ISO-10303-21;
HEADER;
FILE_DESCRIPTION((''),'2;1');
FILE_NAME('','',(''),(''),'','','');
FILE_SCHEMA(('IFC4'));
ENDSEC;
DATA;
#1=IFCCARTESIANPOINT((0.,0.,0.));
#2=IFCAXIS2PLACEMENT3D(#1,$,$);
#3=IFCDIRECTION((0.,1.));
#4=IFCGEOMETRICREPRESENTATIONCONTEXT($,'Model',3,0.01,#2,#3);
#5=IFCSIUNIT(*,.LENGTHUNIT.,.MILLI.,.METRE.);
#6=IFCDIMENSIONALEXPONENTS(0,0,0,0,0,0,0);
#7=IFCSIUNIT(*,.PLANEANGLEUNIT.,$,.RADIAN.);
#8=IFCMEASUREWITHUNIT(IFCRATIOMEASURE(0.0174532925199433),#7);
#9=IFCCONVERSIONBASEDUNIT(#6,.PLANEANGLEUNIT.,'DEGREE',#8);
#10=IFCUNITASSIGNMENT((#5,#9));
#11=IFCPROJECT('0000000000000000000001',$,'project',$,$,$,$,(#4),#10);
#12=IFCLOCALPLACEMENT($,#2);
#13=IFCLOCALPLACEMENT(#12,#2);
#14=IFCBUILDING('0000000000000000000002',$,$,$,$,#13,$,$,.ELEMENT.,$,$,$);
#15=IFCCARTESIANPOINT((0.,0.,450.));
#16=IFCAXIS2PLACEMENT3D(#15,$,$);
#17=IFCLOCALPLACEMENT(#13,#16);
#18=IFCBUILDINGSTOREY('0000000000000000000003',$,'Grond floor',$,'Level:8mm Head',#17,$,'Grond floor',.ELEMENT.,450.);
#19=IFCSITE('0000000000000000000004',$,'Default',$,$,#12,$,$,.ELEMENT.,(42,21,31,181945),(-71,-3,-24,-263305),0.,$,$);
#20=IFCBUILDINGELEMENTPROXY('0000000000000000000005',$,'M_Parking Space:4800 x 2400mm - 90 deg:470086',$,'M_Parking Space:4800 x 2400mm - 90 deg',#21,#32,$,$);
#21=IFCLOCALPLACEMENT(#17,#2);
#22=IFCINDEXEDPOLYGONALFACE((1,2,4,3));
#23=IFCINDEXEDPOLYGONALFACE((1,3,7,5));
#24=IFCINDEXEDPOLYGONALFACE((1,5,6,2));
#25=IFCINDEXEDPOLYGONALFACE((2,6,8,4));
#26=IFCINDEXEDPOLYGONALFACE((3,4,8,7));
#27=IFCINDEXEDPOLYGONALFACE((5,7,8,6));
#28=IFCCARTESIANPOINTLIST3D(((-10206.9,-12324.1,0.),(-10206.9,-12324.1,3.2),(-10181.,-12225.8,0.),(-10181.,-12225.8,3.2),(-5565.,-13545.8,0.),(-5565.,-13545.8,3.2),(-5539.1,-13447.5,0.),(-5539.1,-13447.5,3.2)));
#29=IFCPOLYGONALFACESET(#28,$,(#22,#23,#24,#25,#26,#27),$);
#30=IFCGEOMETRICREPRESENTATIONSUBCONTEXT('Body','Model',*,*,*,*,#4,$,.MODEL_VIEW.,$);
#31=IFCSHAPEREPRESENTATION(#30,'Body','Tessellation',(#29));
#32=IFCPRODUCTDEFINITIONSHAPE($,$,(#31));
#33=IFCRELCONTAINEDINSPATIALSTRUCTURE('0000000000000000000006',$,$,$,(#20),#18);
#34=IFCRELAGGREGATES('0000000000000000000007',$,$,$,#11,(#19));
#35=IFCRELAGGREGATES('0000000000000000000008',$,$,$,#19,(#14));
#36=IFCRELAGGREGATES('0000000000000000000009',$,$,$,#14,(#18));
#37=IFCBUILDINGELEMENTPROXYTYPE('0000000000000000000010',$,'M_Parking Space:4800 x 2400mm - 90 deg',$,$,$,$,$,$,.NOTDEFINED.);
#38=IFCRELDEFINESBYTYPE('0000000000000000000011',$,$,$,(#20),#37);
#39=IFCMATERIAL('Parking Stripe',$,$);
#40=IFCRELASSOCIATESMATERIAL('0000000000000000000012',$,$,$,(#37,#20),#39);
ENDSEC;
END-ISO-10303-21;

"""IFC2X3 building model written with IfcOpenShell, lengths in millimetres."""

from ifc_helpers import new_model, entity, si_unit, converted_unit, direction, frame, origin, origin_2d_with_axis, place, context, subcontext, project, spatial, rectangle, extrude, source, transform, mapped, material, type_object, type_shapes, element, save


model = new_model("IFC2X3")

# Units and contexts
model_context = context("Model", 3, precision=0.01, world=origin(), true_north=direction((0.0, 1.0)))
body_context = subcontext(model_context, "Body", "Model", "MODEL_VIEW")
ifc_project = project(units=[si_unit("LENGTHUNIT", "METRE", prefix="MILLI"), converted_unit("PLANEANGLEUNIT", "DEGREE", entity("IfcRatioMeasure", 0.0174532925199433), si_unit("PLANEANGLEUNIT", "RADIAN"), dimensions=[0, 0, 0, 0, 0, 0, 0])], contexts=[model_context])

# Site, building, storey
site_placement = place(None, origin())
site = spatial("IfcSite", under=ifc_project, at=site_placement, Name="Default", CompositionType="ELEMENT", RefLatitude=(42, 21, 31, 181945), RefLongitude=(-71, -3, -24, -263305), RefElevation=0.0)
building_placement = place(site_placement, origin())
building = spatial("IfcBuilding", under=site, at=building_placement, CompositionType="ELEMENT")
storey_placement = place(building_placement, frame((0.0, 0.0, 450.0)))
storey = spatial("IfcBuildingStorey", under=building, at=storey_placement, Name="Grond floor", ObjectType="Level:8mm Head", LongName="Grond floor", CompositionType="ELEMENT", Elevation=450.0)

# Building element proxy
ifc_material_1 = material(Name="Parking Stripe")
building_element_proxy_type_1 = type_object("IfcBuildingElementProxyType", Name="M_Parking Space:4800 x 2400mm - 90 deg", PredefinedType="NOTDEFINED", material=ifc_material_1)
shared_shape_1 = source(origin(), body_context, "Body", "SweptSolid", [
    extrude(rectangle(XDim=101.6, YDim=4800.0, at=origin_2d_with_axis()), frame((0.0, 2400.0, 0.0)), (0.0, 0.0, 1.0), 3.2),
])
type_shapes(building_element_proxy_type_1, [shared_shape_1])
proxy_1_placement = place(storey_placement, frame((-5552.0, -13496.6, 0.0), z_axis=(0.0, 0.0, 1.0), x_axis=(0.25452, 0.967067, 0.0)))
element("IfcBuildingElementProxy", 1, at=proxy_1_placement, inside=storey, type_object=building_element_proxy_type_1, material=ifc_material_1, Name="M_Parking Space:4800 x 2400mm - 90 deg:470086", ObjectType="M_Parking Space:4800 x 2400mm - 90 deg", context=body_context, shape_type="MappedRepresentation", body=[
    mapped(shared_shape_1, transform((0.0, 0.0, 0.0), scale=1.0)),
])

save(model, "model.ifc")
